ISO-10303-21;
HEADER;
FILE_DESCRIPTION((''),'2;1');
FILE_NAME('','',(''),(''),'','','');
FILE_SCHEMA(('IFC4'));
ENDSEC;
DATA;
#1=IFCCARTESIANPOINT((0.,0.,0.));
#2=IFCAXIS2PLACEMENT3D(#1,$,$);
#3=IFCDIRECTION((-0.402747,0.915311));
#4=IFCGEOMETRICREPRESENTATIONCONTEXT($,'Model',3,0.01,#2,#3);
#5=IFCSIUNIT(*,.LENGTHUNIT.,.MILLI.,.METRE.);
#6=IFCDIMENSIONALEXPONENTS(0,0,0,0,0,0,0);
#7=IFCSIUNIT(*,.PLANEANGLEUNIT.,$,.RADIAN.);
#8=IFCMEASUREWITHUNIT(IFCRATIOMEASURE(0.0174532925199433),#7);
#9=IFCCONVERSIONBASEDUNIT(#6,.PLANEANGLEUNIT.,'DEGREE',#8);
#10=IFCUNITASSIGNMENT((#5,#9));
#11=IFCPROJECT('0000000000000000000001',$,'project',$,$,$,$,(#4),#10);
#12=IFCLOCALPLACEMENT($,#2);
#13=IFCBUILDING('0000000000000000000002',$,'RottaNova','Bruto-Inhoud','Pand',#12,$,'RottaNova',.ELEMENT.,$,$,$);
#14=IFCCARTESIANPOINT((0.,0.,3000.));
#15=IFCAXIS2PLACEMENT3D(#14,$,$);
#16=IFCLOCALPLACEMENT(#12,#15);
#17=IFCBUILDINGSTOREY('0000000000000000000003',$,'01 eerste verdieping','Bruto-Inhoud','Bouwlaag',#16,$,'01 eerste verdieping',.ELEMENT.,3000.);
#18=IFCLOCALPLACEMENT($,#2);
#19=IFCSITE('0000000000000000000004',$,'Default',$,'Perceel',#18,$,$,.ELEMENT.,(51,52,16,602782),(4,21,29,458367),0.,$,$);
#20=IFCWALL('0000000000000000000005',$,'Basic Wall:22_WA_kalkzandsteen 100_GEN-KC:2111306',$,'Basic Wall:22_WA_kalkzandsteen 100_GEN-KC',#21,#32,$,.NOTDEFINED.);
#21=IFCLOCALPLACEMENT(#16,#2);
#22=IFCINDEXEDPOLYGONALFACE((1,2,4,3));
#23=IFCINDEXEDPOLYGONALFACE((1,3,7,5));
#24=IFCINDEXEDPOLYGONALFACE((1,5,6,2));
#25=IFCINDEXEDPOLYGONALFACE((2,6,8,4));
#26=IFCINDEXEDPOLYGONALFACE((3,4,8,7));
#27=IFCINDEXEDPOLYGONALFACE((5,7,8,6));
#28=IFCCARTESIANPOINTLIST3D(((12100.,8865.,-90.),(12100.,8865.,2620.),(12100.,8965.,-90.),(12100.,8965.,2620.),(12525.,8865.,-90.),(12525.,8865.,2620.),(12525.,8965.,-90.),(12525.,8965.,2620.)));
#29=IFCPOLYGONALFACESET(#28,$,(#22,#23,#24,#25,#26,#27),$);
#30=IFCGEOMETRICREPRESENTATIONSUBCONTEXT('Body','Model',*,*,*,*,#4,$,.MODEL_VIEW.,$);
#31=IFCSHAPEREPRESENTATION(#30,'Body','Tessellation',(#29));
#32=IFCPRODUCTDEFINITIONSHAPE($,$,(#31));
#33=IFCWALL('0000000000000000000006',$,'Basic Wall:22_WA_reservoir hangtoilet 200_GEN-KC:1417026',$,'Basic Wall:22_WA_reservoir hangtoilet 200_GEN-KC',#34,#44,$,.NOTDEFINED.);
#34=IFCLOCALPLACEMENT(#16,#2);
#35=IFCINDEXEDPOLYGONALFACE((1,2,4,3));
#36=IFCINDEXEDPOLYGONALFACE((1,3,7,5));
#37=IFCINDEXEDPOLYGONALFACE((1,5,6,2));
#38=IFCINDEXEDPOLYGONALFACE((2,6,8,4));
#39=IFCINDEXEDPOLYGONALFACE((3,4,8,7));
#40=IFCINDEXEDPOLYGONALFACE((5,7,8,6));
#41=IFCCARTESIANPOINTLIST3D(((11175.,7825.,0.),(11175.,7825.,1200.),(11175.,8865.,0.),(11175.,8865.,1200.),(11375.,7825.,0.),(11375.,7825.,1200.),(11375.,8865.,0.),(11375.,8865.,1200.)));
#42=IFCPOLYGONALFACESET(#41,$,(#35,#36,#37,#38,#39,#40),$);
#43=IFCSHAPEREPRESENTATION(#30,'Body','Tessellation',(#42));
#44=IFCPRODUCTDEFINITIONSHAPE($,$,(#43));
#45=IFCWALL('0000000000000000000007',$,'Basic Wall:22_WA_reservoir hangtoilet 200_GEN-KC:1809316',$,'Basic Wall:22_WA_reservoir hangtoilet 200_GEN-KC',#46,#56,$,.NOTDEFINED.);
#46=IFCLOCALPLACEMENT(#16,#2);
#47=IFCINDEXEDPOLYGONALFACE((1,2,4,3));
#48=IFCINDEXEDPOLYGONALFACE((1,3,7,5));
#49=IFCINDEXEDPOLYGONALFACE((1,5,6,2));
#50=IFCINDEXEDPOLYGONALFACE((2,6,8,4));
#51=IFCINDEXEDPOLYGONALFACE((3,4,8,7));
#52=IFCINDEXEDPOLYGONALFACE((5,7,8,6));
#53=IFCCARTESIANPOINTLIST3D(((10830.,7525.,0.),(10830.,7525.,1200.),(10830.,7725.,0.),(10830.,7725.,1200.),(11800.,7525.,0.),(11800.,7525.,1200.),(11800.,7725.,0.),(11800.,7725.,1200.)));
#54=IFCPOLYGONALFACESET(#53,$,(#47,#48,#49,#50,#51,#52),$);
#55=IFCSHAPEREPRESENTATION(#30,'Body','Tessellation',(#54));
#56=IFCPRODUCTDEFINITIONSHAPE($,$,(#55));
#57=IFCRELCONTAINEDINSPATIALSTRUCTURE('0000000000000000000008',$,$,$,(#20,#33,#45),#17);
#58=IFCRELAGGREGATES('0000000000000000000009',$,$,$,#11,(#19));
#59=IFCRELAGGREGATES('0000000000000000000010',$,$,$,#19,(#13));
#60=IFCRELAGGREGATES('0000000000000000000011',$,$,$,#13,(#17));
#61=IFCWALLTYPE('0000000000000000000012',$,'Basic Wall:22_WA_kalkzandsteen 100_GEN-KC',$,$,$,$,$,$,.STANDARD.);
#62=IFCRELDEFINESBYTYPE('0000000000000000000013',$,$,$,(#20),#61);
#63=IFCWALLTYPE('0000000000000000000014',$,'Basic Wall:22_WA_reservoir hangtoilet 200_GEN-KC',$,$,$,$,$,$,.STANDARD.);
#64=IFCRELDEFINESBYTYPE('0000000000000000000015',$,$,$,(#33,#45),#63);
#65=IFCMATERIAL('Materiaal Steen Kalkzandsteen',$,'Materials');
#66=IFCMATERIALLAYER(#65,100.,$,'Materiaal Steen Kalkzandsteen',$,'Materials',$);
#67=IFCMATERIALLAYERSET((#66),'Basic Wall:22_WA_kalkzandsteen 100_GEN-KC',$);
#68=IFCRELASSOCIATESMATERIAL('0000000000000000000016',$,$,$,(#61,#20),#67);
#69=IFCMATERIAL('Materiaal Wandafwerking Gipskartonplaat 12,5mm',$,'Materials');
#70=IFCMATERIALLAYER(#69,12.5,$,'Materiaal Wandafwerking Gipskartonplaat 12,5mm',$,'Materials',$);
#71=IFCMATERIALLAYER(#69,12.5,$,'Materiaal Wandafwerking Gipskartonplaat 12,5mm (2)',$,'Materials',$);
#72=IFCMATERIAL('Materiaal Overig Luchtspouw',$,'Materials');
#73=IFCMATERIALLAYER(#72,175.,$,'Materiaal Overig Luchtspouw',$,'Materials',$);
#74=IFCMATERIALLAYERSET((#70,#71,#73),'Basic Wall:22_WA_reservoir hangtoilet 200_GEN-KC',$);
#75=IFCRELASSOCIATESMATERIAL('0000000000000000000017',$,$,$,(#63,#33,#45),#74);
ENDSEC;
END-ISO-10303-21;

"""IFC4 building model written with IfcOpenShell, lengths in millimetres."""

from ifc_helpers import new_model, entity, si_unit, converted_unit, direction, frame, frame_2d, origin, place, context, subcontext, project, spatial, rectangle, extrude, material, layer, layer_set, type_object, element, save


model = new_model("IFC4")

# Units and contexts
model_context = context("Model", 3, precision=0.01, world=origin(), true_north=direction((-0.402747, 0.915311)))
body_context = subcontext(model_context, "Body", "Model", "MODEL_VIEW")
ifc_project = project(units=[si_unit("LENGTHUNIT", "METRE", prefix="MILLI"), converted_unit("PLANEANGLEUNIT", "DEGREE", entity("IfcRatioMeasure", 0.0174532925199433), si_unit("PLANEANGLEUNIT", "RADIAN"), dimensions=[0, 0, 0, 0, 0, 0, 0])], contexts=[model_context])

# Site, building, storey
site_placement = place(None, origin())
site = spatial("IfcSite", under=ifc_project, at=site_placement, Name="Default", ObjectType="Perceel", CompositionType="ELEMENT", RefLatitude=(51, 52, 16, 602782), RefLongitude=(4, 21, 29, 458367), RefElevation=0.0)
building_placement = place(None, origin())
building = spatial("IfcBuilding", under=site, at=building_placement, Name="RottaNova", Description="Bruto-Inhoud", ObjectType="Pand", LongName="RottaNova", CompositionType="ELEMENT")
storey_placement = place(building_placement, frame((0.0, 0.0, 3000.0)))
storey = spatial("IfcBuildingStorey", under=building, at=storey_placement, Name="01 eerste verdieping", Description="Bruto-Inhoud", ObjectType="Bouwlaag", LongName="01 eerste verdieping", CompositionType="ELEMENT", Elevation=3000.0)

# Shared definitions
ifc_material_1 = material(Name="Materiaal Steen Kalkzandsteen", Category="Materials")

# Walls
ifc_layer_1 = layer(ifc_material_1, 100.0, Name="Materiaal Steen Kalkzandsteen", Category="Materials")
ifc_layer_set_1 = layer_set([ifc_layer_1], Name="Basic Wall:22_WA_kalkzandsteen 100_GEN-KC")
wall_type_1 = type_object("IfcWallType", Name="Basic Wall:22_WA_kalkzandsteen 100_GEN-KC", PredefinedType="STANDARD", material=ifc_layer_set_1)
wall_1_placement = place(storey_placement, frame((12100.0, 8915.0, -90.0)))
element("IfcWall", 1, at=wall_1_placement, inside=storey, type_object=wall_type_1, material=ifc_layer_set_1, Name="Basic Wall:22_WA_kalkzandsteen 100_GEN-KC:2111306", ObjectType="Basic Wall:22_WA_kalkzandsteen 100_GEN-KC", PredefinedType="NOTDEFINED", context=body_context, shape_type="SweptSolid", body=[
    extrude(rectangle(XDim=425.0, YDim=100.0, at=frame_2d((212.5, 0.0), x_axis=(-1.0, 0.0))), origin(), (0.0, 0.0, 1.0), 2710.0),
])
ifc_material_2 = material(Name="Materiaal Wandafwerking Gipskartonplaat 12,5mm", Category="Materials")
ifc_layer_2 = layer(ifc_material_2, 12.5, Name="Materiaal Wandafwerking Gipskartonplaat 12,5mm", Category="Materials")
ifc_layer_3 = layer(ifc_material_2, 12.5, Name="Materiaal Wandafwerking Gipskartonplaat 12,5mm (2)", Category="Materials")
ifc_material_3 = material(Name="Materiaal Overig Luchtspouw", Category="Materials")
ifc_layer_4 = layer(ifc_material_3, 175.0, Name="Materiaal Overig Luchtspouw", Category="Materials")
ifc_layer_set_2 = layer_set([ifc_layer_2, ifc_layer_3, ifc_layer_4], Name="Basic Wall:22_WA_reservoir hangtoilet 200_GEN-KC")
wall_type_2 = type_object("IfcWallType", Name="Basic Wall:22_WA_reservoir hangtoilet 200_GEN-KC", PredefinedType="STANDARD", material=ifc_layer_set_2)
wall_2_placement = place(storey_placement, frame((11275.0, 8865.0, 0.0), z_axis=(0.0, 0.0, 1.0), x_axis=(0.0, -1.0, 0.0)))
element("IfcWall", 2, at=wall_2_placement, inside=storey, type_object=wall_type_2, material=ifc_layer_set_2, Name="Basic Wall:22_WA_reservoir hangtoilet 200_GEN-KC:1417026", ObjectType="Basic Wall:22_WA_reservoir hangtoilet 200_GEN-KC", PredefinedType="NOTDEFINED", context=body_context, shape_type="SweptSolid", body=[
    extrude(rectangle(XDim=1040.0, YDim=200.0, at=frame_2d((520.0, 0.0), x_axis=(-1.0, 0.0))), origin(), (0.0, 0.0, 1.0), 1200.0),
])
wall_3_placement = place(storey_placement, frame((10830.0, 7625.0, 0.0)))
element("IfcWall", 3, at=wall_3_placement, inside=storey, type_object=wall_type_2, material=ifc_layer_set_2, Name="Basic Wall:22_WA_reservoir hangtoilet 200_GEN-KC:1809316", ObjectType="Basic Wall:22_WA_reservoir hangtoilet 200_GEN-KC", PredefinedType="NOTDEFINED", context=body_context, shape_type="SweptSolid", body=[
    extrude(rectangle(XDim=970.0, YDim=200.0, at=frame_2d((485.0, 0.0), x_axis=(-1.0, 0.0))), origin(), (0.0, 0.0, 1.0), 1200.0),
])

save(model, "model.ifc")
